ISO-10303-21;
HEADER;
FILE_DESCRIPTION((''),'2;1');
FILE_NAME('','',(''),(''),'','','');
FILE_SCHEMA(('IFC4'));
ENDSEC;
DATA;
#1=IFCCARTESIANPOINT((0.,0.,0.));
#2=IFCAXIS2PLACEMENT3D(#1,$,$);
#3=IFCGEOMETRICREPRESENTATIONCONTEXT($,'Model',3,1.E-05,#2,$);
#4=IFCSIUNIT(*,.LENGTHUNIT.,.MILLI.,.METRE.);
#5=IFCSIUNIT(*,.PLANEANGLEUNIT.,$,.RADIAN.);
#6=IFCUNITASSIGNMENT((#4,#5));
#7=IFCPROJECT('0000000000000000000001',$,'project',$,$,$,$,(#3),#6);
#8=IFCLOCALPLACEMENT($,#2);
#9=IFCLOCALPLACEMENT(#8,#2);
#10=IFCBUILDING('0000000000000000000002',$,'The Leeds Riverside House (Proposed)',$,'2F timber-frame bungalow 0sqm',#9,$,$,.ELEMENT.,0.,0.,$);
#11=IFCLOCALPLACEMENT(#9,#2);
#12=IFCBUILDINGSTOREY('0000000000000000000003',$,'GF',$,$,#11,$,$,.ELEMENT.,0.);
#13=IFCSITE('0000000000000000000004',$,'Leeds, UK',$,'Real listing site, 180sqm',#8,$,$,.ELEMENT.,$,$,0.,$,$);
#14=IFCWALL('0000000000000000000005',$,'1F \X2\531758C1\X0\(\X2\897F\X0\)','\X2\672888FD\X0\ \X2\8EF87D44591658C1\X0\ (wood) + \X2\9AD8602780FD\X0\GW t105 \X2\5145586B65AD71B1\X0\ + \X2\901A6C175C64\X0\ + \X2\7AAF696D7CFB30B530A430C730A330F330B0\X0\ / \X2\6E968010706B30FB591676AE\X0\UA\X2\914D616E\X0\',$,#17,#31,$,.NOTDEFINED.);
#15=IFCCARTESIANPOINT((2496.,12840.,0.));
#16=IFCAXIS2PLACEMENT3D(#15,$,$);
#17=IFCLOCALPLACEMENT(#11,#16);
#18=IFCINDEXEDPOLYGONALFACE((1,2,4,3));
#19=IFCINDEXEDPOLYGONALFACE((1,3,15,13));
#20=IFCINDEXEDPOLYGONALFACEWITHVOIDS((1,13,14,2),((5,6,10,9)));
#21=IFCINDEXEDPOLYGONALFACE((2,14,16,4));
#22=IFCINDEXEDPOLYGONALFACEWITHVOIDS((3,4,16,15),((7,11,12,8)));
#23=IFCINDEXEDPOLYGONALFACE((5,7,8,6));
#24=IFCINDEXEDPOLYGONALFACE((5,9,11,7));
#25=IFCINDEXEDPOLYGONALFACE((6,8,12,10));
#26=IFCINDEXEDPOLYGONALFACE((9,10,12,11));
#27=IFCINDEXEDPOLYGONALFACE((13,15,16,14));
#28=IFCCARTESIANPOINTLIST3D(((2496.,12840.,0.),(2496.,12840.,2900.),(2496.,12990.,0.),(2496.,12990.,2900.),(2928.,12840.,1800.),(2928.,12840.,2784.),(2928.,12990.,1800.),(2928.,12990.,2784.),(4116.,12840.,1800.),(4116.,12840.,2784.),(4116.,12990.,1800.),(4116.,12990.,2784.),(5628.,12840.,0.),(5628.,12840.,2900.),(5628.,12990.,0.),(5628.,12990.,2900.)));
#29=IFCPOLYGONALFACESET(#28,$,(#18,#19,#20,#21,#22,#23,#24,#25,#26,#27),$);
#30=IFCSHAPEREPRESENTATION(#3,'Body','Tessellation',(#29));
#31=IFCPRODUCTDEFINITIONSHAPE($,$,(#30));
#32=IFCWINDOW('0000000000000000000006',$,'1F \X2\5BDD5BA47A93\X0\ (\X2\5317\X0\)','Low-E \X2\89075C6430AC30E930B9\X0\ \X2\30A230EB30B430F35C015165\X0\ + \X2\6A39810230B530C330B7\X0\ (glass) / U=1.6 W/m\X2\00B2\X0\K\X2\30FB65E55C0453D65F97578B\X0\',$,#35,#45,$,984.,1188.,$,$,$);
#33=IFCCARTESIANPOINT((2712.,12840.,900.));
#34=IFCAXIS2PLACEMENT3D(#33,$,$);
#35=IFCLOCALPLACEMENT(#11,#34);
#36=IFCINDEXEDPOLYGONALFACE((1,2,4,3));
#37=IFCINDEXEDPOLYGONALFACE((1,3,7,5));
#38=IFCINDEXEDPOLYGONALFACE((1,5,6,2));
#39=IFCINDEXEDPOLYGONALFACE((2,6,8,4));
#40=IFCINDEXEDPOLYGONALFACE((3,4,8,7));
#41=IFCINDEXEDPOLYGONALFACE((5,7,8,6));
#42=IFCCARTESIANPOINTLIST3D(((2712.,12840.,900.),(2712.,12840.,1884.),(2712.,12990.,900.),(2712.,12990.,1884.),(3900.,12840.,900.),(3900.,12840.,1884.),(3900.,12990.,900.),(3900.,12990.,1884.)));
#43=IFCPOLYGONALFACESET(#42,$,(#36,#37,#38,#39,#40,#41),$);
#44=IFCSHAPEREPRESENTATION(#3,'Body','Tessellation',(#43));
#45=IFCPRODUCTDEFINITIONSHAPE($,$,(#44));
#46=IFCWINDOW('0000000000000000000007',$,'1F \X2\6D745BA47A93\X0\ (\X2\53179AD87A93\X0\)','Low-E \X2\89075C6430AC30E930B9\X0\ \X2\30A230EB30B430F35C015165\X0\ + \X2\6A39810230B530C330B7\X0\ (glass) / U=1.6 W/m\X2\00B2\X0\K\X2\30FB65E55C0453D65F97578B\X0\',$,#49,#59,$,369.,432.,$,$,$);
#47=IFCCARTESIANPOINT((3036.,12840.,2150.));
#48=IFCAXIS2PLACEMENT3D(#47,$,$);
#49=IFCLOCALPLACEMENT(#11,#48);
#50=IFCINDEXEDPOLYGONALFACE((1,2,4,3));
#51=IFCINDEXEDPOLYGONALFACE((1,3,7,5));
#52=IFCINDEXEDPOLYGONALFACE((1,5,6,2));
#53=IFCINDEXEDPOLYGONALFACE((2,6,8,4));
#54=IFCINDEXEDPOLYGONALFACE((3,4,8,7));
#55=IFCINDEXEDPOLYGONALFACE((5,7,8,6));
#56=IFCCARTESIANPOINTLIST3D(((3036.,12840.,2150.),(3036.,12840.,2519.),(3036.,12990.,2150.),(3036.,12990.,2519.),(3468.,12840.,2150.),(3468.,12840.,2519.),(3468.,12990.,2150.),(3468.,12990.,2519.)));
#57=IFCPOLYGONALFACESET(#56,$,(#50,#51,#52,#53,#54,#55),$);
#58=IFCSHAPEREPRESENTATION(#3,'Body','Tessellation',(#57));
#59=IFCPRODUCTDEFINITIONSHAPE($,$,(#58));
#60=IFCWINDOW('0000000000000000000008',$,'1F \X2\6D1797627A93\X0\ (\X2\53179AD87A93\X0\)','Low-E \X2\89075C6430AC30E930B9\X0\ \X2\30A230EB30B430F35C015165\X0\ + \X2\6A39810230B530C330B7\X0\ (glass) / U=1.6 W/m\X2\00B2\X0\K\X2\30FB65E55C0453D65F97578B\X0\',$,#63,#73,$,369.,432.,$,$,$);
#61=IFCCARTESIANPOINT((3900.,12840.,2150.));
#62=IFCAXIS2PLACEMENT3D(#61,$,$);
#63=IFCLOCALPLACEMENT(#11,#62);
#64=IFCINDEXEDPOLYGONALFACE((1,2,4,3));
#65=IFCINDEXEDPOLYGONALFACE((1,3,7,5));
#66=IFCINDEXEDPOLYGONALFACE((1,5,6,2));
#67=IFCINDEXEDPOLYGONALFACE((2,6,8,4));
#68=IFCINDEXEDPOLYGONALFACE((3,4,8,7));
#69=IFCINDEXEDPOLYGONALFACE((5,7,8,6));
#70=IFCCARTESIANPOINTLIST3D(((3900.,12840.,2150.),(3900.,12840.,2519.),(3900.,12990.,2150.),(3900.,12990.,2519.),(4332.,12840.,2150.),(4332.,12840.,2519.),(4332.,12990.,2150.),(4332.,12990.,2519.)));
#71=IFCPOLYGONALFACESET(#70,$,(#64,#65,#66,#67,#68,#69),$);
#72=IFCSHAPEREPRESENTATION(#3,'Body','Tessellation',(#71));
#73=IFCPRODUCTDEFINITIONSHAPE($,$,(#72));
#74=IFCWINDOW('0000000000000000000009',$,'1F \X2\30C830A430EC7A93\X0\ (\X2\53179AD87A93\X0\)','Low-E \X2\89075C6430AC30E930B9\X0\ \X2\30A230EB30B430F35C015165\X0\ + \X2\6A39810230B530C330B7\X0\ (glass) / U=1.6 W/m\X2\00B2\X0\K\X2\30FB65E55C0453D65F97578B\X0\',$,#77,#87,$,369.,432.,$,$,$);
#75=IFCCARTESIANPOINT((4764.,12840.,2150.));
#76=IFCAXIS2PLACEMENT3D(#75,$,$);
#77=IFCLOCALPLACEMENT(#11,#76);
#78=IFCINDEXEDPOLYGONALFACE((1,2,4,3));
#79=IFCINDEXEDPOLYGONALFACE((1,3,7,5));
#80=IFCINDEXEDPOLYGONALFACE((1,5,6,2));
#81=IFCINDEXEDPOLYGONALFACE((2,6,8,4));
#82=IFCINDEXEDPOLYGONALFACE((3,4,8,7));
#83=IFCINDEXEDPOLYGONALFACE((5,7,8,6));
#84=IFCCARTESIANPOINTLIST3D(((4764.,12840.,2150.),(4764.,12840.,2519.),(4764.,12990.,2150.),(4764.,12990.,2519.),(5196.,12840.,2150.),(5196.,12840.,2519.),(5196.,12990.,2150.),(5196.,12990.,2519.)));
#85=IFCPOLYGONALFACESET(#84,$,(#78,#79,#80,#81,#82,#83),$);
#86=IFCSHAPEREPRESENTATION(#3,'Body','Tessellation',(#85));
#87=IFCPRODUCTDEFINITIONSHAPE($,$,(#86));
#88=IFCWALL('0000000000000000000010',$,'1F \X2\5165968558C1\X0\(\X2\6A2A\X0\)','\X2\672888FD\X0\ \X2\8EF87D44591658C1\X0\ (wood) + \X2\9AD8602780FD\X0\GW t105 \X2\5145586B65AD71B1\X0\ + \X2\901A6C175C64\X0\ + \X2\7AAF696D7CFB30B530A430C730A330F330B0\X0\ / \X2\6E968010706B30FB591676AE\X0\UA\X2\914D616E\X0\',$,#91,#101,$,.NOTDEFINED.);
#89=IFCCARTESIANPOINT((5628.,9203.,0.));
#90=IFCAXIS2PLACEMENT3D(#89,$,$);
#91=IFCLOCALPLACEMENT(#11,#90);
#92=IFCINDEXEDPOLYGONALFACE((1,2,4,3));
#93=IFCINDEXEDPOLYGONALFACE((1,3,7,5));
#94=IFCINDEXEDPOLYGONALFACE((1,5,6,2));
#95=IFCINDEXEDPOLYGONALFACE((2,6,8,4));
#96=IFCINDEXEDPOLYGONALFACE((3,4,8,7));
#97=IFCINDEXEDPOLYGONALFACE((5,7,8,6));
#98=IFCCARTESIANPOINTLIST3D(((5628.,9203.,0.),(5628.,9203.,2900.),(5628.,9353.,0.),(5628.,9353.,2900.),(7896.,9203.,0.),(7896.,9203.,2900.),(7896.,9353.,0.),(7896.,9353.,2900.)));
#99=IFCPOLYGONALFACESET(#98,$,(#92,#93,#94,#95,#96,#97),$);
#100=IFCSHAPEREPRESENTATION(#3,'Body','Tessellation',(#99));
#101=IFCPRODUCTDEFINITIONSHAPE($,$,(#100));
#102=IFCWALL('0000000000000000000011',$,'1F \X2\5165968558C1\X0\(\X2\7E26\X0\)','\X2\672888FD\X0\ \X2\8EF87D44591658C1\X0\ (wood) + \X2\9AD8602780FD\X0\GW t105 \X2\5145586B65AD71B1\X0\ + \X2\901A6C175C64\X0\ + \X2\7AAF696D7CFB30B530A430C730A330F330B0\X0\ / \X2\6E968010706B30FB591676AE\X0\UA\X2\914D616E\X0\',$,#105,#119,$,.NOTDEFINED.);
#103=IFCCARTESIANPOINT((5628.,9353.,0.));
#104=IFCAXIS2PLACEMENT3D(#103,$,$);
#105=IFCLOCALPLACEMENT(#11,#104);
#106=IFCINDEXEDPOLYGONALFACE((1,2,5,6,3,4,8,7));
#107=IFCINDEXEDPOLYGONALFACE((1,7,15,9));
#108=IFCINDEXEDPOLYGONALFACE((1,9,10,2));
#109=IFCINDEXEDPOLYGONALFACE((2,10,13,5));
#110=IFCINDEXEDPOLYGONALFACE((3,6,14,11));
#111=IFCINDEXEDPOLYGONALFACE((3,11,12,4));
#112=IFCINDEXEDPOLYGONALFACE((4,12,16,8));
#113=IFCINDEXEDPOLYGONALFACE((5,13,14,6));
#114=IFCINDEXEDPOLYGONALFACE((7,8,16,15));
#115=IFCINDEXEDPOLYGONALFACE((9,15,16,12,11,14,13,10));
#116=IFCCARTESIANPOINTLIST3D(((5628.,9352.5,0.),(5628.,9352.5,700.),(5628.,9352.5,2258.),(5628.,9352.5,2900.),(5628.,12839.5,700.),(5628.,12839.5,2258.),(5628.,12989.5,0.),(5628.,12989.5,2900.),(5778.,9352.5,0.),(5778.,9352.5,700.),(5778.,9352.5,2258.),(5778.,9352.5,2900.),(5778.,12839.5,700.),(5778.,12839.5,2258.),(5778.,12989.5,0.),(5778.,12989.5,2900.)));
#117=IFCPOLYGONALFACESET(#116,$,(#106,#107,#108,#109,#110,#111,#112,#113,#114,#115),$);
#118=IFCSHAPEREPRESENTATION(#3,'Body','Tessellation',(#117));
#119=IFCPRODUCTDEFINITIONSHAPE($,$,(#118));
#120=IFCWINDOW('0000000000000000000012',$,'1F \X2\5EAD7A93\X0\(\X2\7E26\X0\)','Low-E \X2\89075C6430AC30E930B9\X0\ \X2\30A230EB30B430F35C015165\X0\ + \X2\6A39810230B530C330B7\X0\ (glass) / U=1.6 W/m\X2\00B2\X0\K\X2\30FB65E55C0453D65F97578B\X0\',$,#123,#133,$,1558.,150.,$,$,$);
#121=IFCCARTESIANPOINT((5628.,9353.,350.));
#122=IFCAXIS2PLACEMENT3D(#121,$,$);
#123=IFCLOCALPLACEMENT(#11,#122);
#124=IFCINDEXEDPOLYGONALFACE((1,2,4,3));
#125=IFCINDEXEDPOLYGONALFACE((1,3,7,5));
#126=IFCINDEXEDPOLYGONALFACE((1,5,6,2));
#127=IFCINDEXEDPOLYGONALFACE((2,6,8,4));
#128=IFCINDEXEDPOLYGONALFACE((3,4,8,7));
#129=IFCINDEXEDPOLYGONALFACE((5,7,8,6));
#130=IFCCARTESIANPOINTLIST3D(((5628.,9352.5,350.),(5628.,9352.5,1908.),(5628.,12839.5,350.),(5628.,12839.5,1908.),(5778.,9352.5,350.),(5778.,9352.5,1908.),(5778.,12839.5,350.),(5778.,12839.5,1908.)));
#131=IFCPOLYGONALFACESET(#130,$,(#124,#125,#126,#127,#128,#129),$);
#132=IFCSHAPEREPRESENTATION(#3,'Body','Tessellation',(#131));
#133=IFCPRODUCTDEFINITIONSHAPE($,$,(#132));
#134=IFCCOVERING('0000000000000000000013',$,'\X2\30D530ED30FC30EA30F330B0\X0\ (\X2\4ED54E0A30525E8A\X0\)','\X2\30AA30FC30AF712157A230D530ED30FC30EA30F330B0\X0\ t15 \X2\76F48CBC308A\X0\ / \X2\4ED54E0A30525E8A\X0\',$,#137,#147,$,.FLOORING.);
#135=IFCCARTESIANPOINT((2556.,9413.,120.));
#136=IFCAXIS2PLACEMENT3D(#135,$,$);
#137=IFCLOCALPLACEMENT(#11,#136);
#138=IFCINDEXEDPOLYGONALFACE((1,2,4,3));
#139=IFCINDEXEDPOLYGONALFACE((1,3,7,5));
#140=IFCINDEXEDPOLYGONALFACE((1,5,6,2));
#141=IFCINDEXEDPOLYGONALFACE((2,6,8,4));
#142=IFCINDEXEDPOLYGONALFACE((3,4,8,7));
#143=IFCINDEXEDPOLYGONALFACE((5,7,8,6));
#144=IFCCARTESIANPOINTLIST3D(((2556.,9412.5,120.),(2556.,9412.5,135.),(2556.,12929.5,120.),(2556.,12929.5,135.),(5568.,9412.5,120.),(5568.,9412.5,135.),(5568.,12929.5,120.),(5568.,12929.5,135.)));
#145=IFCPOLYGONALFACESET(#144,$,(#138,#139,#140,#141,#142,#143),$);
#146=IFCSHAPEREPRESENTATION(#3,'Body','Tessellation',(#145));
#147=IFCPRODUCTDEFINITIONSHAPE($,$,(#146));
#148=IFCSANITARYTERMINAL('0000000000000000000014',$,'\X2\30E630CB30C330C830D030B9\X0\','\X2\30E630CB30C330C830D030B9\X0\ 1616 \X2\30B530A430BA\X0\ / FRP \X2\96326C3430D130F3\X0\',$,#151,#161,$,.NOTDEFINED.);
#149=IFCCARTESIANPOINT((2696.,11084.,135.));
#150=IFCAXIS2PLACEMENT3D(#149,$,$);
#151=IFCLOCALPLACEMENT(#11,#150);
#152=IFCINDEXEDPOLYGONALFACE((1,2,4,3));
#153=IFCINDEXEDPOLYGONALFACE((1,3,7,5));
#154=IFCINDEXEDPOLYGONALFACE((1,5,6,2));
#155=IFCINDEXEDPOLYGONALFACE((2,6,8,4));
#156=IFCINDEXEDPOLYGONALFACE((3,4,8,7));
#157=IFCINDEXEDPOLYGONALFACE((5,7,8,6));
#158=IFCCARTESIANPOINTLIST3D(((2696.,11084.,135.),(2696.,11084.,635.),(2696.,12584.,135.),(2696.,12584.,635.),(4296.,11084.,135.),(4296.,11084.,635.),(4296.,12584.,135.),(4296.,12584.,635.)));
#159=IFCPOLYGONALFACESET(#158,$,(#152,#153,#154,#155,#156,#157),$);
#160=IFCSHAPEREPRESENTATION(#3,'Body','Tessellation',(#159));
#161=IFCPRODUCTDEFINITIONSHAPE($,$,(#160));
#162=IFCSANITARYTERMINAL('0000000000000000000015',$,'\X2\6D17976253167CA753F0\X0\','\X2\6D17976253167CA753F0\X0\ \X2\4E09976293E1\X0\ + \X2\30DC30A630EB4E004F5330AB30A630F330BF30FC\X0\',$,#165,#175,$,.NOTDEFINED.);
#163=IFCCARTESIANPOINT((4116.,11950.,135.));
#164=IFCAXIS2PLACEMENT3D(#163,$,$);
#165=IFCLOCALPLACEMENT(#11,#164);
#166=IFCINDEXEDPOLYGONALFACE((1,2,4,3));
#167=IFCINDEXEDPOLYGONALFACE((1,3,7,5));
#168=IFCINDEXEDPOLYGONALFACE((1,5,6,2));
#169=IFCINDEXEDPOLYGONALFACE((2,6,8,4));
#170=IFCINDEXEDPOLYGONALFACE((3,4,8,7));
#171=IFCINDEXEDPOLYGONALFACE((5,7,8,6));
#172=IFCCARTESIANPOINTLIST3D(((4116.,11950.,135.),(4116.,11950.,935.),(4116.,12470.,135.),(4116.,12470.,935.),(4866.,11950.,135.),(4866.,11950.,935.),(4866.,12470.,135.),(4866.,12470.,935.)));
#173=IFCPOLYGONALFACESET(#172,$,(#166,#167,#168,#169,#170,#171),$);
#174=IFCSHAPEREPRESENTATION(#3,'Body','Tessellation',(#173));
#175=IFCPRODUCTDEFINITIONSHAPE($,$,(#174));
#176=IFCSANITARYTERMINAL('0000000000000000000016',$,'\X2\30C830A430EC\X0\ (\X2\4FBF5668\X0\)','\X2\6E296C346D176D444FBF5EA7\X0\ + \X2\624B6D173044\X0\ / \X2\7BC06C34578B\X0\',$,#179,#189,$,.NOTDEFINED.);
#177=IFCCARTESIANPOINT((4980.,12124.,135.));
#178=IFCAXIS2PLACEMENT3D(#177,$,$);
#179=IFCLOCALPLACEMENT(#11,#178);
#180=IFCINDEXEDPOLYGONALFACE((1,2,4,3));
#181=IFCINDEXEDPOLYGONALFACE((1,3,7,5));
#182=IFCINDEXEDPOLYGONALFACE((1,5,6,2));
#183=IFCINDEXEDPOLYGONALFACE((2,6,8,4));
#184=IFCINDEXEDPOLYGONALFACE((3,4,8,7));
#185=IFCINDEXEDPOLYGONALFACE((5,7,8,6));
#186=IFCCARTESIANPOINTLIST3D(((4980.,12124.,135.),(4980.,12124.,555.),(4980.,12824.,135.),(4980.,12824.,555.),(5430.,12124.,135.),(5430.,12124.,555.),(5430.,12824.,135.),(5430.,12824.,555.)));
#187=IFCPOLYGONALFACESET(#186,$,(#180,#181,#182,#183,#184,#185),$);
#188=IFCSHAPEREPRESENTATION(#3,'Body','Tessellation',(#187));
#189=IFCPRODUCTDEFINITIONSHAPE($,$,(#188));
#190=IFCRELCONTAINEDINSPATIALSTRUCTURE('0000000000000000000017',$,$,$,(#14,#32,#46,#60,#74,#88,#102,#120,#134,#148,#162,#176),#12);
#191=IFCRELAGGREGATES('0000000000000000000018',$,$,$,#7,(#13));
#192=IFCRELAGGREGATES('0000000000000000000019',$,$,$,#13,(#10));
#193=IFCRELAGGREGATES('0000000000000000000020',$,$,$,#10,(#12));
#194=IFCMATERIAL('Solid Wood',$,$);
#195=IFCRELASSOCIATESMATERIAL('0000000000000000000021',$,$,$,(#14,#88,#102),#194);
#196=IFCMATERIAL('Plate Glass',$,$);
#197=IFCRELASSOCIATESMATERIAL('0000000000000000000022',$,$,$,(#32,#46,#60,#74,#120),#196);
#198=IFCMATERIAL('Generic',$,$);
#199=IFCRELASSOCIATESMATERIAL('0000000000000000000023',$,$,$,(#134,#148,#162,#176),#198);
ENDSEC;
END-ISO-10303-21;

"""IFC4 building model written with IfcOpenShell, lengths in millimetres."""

from ifc_helpers import new_model, si_unit, frame, frame_2d, origin, place, context, project, spatial, rectangle, extrude, material, element, fill, save


model = new_model("IFC4")

# Units and contexts
model_context = context("Model", 3, precision=1e-05, world=origin())
ifc_project = project(units=[si_unit("LENGTHUNIT", "METRE", prefix="MILLI"), si_unit("PLANEANGLEUNIT", "RADIAN")], contexts=[model_context])

# Site, building, storey
site_placement = place(None, origin())
site = spatial("IfcSite", under=ifc_project, at=site_placement, Name="Leeds, UK", ObjectType="Real listing site, 180sqm", CompositionType="ELEMENT", RefElevation=0.0)
building_placement = place(site_placement, origin())
building = spatial("IfcBuilding", under=site, at=building_placement, Name="The Leeds Riverside House (Proposed)", ObjectType="2F timber-frame bungalow 0sqm", CompositionType="ELEMENT", ElevationOfRefHeight=0.0, ElevationOfTerrain=0.0)
storey_placement = place(building_placement, origin())
storey = spatial("IfcBuildingStorey", under=building, at=storey_placement, Name="GF", CompositionType="ELEMENT", Elevation=0.0)

# Shared definitions
ifc_material_1 = material(Name="Solid Wood")

# Wall, openings, windows
wall_1_placement = place(storey_placement, frame((2496.0, 12840.0, 0.0)))
wall_1 = element("IfcWall", 1, at=wall_1_placement, inside=storey, material=ifc_material_1, Name="1F 北壁(西)", Description="木製 軸組外壁 (wood) + 高性能GW t105 充填断熱 + 通気層 + 窯業系サイディング / 準耐火・外皮UA配慮", PredefinedType="NOTDEFINED", context=model_context, shape_type="SweptSolid", body=[
    extrude(rectangle(XDim=3132.0, YDim=150.0, at=frame_2d((1566.0, 75.0))), frame((2496.0, 12840.0, 0.0)), (0.0, 0.0, 1.0), 2900.0),
])
opening_1_placement = place(storey_placement, frame((2712.0, 12840.0, 900.0)))
opening_1 = element("IfcOpeningElement", 2, at=opening_1_placement, cuts=wall_1, PredefinedType="NOTDEFINED", context=model_context, shape_type="SweptSolid", body=[
    extrude(rectangle(XDim=1188.0, YDim=150.0, at=frame_2d((594.0, 75.0))), frame((2712.0, 12840.0, 900.0)), (0.0, 0.0, 1.0), 984.0),
])
opening_2_placement = place(storey_placement, frame((3036.0, 12840.0, 2150.0)))
opening_2 = element("IfcOpeningElement", 3, at=opening_2_placement, cuts=wall_1, PredefinedType="NOTDEFINED", context=model_context, shape_type="SweptSolid", body=[
    extrude(rectangle(XDim=432.0, YDim=150.0, at=frame_2d((216.0, 75.0))), frame((3036.0, 12840.0, 2150.0)), (0.0, 0.0, 1.0), 369.0),
])
opening_3_placement = place(storey_placement, frame((3900.0, 12840.0, 2150.0)))
opening_3 = element("IfcOpeningElement", 4, at=opening_3_placement, cuts=wall_1, PredefinedType="NOTDEFINED", context=model_context, shape_type="SweptSolid", body=[
    extrude(rectangle(XDim=432.0, YDim=150.0, at=frame_2d((216.0, 75.0))), frame((3900.0, 12840.0, 2150.0)), (0.0, 0.0, 1.0), 369.0),
])
opening_4_placement = place(storey_placement, frame((4764.0, 12840.0, 2150.0)))
opening_4 = element("IfcOpeningElement", 5, at=opening_4_placement, cuts=wall_1, PredefinedType="NOTDEFINED", context=model_context, shape_type="SweptSolid", body=[
    extrude(rectangle(XDim=432.0, YDim=150.0, at=frame_2d((216.0, 75.0))), frame((4764.0, 12840.0, 2150.0)), (0.0, 0.0, 1.0), 369.0),
])
ifc_material_2 = material(Name="Plate Glass")
window_1_placement = place(storey_placement, frame((2712.0, 12840.0, 900.0)))
window_1 = element("IfcWindow", 6, at=window_1_placement, inside=storey, material=ifc_material_2, Name="1F 寝室窓 (北)", Description="Low-E 複層ガラス アルゴン封入 + 樹脂サッシ (glass) / U=1.6 W/m²K・日射取得型", OverallHeight=984.0, OverallWidth=1188.0, context=model_context, shape_type="SweptSolid", body=[
    extrude(rectangle(XDim=1188.0, YDim=150.0, at=frame_2d((594.0, 75.0))), frame((2712.0, 12840.0, 900.0)), (0.0, 0.0, 1.0), 984.0),
])
fill(opening_1, window_1)
window_2_placement = place(storey_placement, frame((3036.0, 12840.0, 2150.0)))
window_2 = element("IfcWindow", 7, at=window_2_placement, inside=storey, material=ifc_material_2, Name="1F 浴室窓 (北高窓)", Description="Low-E 複層ガラス アルゴン封入 + 樹脂サッシ (glass) / U=1.6 W/m²K・日射取得型", OverallHeight=369.0, OverallWidth=432.0, context=model_context, shape_type="SweptSolid", body=[
    extrude(rectangle(XDim=432.0, YDim=150.0, at=frame_2d((216.0, 75.0))), frame((3036.0, 12840.0, 2150.0)), (0.0, 0.0, 1.0), 369.0),
])
fill(opening_2, window_2)
window_3_placement = place(storey_placement, frame((3900.0, 12840.0, 2150.0)))
window_3 = element("IfcWindow", 8, at=window_3_placement, inside=storey, material=ifc_material_2, Name="1F 洗面窓 (北高窓)", Description="Low-E 複層ガラス アルゴン封入 + 樹脂サッシ (glass) / U=1.6 W/m²K・日射取得型", OverallHeight=369.0, OverallWidth=432.0, context=model_context, shape_type="SweptSolid", body=[
    extrude(rectangle(XDim=432.0, YDim=150.0, at=frame_2d((216.0, 75.0))), frame((3900.0, 12840.0, 2150.0)), (0.0, 0.0, 1.0), 369.0),
])
fill(opening_3, window_3)
window_4_placement = place(storey_placement, frame((4764.0, 12840.0, 2150.0)))
window_4 = element("IfcWindow", 9, at=window_4_placement, inside=storey, material=ifc_material_2, Name="1F トイレ窓 (北高窓)", Description="Low-E 複層ガラス アルゴン封入 + 樹脂サッシ (glass) / U=1.6 W/m²K・日射取得型", OverallHeight=369.0, OverallWidth=432.0, context=model_context, shape_type="SweptSolid", body=[
    extrude(rectangle(XDim=432.0, YDim=150.0, at=frame_2d((216.0, 75.0))), frame((4764.0, 12840.0, 2150.0)), (0.0, 0.0, 1.0), 369.0),
])
fill(opening_4, window_4)

# Wall
wall_2_placement = place(storey_placement, frame((5628.0, 9203.0, 0.0)))
element("IfcWall", 10, at=wall_2_placement, inside=storey, material=ifc_material_1, Name="1F 入隅壁(横)", Description="木製 軸組外壁 (wood) + 高性能GW t105 充填断熱 + 通気層 + 窯業系サイディング / 準耐火・外皮UA配慮", PredefinedType="NOTDEFINED", context=model_context, shape_type="SweptSolid", body=[
    extrude(rectangle(XDim=2268.0, YDim=150.0, at=frame_2d((1134.0, 75.0))), frame((5628.0, 9203.0, 0.0)), (0.0, 0.0, 1.0), 2900.0),
])

# Wall, opening, window
wall_3_placement = place(storey_placement, frame((5628.0, 9353.0, 0.0)))
wall_3 = element("IfcWall", 11, at=wall_3_placement, inside=storey, material=ifc_material_1, Name="1F 入隅壁(縦)", Description="木製 軸組外壁 (wood) + 高性能GW t105 充填断熱 + 通気層 + 窯業系サイディング / 準耐火・外皮UA配慮", PredefinedType="NOTDEFINED", context=model_context, shape_type="SweptSolid", body=[
    extrude(rectangle(XDim=150.0, YDim=3637.0, at=frame_2d((75.0, 1818.0))), frame((5628.0, 9353.0, 0.0)), (0.0, 0.0, 1.0), 2900.0),
])
opening_5_placement = place(storey_placement, frame((5628.0, 9353.0, 350.0)))
opening_5 = element("IfcOpeningElement", 12, at=opening_5_placement, cuts=wall_3, PredefinedType="NOTDEFINED", context=model_context, shape_type="SweptSolid", body=[
    extrude(rectangle(XDim=150.0, YDim=3487.0, at=frame_2d((75.0, 1743.0))), frame((5628.0, 9353.0, 350.0)), (0.0, 0.0, 1.0), 1558.0),
])
window_5_placement = place(storey_placement, frame((5628.0, 9353.0, 350.0)))
window_5 = element("IfcWindow", 13, at=window_5_placement, inside=storey, material=ifc_material_2, Name="1F 庭窓(縦)", Description="Low-E 複層ガラス アルゴン封入 + 樹脂サッシ (glass) / U=1.6 W/m²K・日射取得型", OverallHeight=1558.0, OverallWidth=150.0, context=model_context, shape_type="SweptSolid", body=[
    extrude(rectangle(XDim=150.0, YDim=3487.0, at=frame_2d((75.0, 1743.0))), frame((5628.0, 9353.0, 350.0)), (0.0, 0.0, 1.0), 1558.0),
])
fill(opening_5, window_5)

# Covering
ifc_material_3 = material(Name="Generic")
covering_placement = place(storey_placement, frame((2556.0, 9413.0, 120.0)))
element("IfcCovering", 14, at=covering_placement, inside=storey, material=ifc_material_3, Name="フローリング (仕上げ床)", Description="オーク無垢フローリング t15 直貼り / 仕上げ床", PredefinedType="FLOORING", context=model_context, shape_type="SweptSolid", body=[
    extrude(rectangle(XDim=3012.0, YDim=3517.0, at=frame_2d((1506.0, 1758.0))), frame((2556.0, 9413.0, 120.0)), (0.0, 0.0, 1.0), 15.0),
])

# Sanitary terminals
sanitary_terminal_1_placement = place(storey_placement, frame((2696.0, 11084.0, 135.0)))
element("IfcSanitaryTerminal", 15, at=sanitary_terminal_1_placement, inside=storey, material=ifc_material_3, Name="ユニットバス", Description="ユニットバス 1616 サイズ / FRP 防水パン", PredefinedType="NOTDEFINED", context=model_context, shape_type="SweptSolid", body=[
    extrude(rectangle(XDim=1600.0, YDim=1500.0, at=frame_2d((800.0, 750.0))), frame((2696.0, 11084.0, 135.0)), (0.0, 0.0, 1.0), 500.0),
])
sanitary_terminal_2_placement = place(storey_placement, frame((4116.0, 11950.0, 135.0)))
element("IfcSanitaryTerminal", 16, at=sanitary_terminal_2_placement, inside=storey, material=ifc_material_3, Name="洗面化粧台", Description="洗面化粧台 三面鏡 + ボウル一体カウンター", PredefinedType="NOTDEFINED", context=model_context, shape_type="SweptSolid", body=[
    extrude(rectangle(XDim=750.0, YDim=520.0, at=frame_2d((375.0, 260.0))), frame((4116.0, 11950.0, 135.0)), (0.0, 0.0, 1.0), 800.0),
])
sanitary_terminal_3_placement = place(storey_placement, frame((4980.0, 12124.0, 135.0)))
element("IfcSanitaryTerminal", 17, at=sanitary_terminal_3_placement, inside=storey, material=ifc_material_3, Name="トイレ (便器)", Description="温水洗浄便座 + 手洗い / 節水型", PredefinedType="NOTDEFINED", context=model_context, shape_type="SweptSolid", body=[
    extrude(rectangle(XDim=450.0, YDim=700.0, at=frame_2d((225.0, 350.0))), frame((4980.0, 12124.0, 135.0)), (0.0, 0.0, 1.0), 420.0),
])

save(model, "model.ifc")
